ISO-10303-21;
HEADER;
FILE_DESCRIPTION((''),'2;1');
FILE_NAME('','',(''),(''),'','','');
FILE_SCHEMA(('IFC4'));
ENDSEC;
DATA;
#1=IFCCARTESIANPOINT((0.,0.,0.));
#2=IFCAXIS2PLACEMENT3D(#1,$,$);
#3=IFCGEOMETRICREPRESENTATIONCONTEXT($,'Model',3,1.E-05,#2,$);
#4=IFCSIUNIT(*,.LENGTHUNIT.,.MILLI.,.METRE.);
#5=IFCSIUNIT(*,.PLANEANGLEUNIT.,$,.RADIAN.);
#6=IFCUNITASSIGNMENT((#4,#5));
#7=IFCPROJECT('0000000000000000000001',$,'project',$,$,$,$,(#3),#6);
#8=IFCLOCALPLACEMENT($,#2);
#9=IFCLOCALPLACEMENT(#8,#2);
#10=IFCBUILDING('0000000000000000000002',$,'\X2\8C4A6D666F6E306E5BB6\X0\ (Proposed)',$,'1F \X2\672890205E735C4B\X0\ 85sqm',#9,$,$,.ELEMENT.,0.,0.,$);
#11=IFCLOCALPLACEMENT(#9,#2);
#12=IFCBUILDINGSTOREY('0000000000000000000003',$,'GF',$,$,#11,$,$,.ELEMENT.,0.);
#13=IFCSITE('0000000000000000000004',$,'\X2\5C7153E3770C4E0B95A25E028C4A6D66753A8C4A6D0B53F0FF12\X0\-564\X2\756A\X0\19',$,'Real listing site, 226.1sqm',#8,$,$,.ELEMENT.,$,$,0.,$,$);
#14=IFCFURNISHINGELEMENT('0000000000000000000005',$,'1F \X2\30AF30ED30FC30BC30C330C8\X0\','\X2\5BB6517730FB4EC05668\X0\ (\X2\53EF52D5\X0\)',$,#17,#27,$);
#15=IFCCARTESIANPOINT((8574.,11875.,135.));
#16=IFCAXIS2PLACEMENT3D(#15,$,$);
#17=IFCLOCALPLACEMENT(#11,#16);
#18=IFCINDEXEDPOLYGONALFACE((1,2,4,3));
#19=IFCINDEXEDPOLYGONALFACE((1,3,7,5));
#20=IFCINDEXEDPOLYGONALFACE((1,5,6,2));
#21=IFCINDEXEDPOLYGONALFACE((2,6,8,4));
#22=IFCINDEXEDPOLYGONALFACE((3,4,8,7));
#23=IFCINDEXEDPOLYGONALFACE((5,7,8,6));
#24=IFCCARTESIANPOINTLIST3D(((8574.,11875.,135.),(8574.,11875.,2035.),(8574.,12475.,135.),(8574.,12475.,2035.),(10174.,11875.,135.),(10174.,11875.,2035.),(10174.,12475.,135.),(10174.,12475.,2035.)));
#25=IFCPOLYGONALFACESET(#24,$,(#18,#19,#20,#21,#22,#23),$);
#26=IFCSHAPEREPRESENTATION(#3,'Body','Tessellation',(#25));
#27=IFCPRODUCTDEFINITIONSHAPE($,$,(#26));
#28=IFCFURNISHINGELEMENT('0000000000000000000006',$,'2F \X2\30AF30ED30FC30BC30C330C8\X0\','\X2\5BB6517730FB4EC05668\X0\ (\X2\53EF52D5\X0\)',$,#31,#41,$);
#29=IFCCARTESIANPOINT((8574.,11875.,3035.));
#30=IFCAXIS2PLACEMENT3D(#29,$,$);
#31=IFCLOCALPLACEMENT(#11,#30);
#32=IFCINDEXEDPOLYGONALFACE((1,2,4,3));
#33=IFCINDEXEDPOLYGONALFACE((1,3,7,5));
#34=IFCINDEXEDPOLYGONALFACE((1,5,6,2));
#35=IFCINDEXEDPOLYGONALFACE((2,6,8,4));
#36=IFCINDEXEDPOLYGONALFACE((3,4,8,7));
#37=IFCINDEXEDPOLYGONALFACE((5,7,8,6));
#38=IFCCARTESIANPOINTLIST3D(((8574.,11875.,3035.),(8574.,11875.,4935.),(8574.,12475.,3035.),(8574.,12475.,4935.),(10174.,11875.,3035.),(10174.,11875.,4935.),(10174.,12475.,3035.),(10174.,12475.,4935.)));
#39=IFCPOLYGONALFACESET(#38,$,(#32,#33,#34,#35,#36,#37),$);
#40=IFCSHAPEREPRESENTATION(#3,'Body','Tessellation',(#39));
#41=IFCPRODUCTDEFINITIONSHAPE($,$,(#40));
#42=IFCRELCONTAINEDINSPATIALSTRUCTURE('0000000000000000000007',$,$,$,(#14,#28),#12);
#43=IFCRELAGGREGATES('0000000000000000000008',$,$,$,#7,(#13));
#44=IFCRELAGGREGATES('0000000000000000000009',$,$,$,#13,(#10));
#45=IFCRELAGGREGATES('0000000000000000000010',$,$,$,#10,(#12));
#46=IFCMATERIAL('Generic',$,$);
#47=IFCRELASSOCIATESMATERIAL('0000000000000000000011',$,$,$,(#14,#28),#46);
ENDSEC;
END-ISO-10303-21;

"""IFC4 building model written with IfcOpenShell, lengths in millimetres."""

from ifc_helpers import new_model, si_unit, frame, frame_2d, origin, place, context, project, spatial, rectangle, extrude, material, element, save


model = new_model("IFC4")

# Units and contexts
model_context = context("Model", 3, precision=1e-05, world=origin())
ifc_project = project(units=[si_unit("LENGTHUNIT", "METRE", prefix="MILLI"), si_unit("PLANEANGLEUNIT", "RADIAN")], contexts=[model_context])

# Site, building, storey
site_placement = place(None, origin())
site = spatial("IfcSite", under=ifc_project, at=site_placement, Name="山口県下関市豊浦町豊洋台２-564番19", ObjectType="Real listing site, 226.1sqm", CompositionType="ELEMENT", RefElevation=0.0)
building_placement = place(site_placement, origin())
building = spatial("IfcBuilding", under=site, at=building_placement, Name="豊浦潮の家 (Proposed)", ObjectType="1F 木造平屋 85sqm", CompositionType="ELEMENT", ElevationOfRefHeight=0.0, ElevationOfTerrain=0.0)
storey_placement = place(building_placement, origin())
storey = spatial("IfcBuildingStorey", under=building, at=storey_placement, Name="GF", CompositionType="ELEMENT", Elevation=0.0)

# Shared definitions
ifc_material_1 = material(Name="Generic")

# Furnishing elements
furnishing_1_placement = place(storey_placement, frame((8574.0, 11875.0, 135.0)))
element("IfcFurnishingElement", 1, at=furnishing_1_placement, inside=storey, material=ifc_material_1, Name="1F クローゼット", Description="家具・什器 (可動)", context=model_context, shape_type="SweptSolid", body=[
    extrude(rectangle(XDim=1600.0, YDim=600.0, at=frame_2d((800.0, 300.0))), frame((8574.0, 11875.0, 135.0)), (0.0, 0.0, 1.0), 1900.0),
])
furnishing_2_placement = place(storey_placement, frame((8574.0, 11875.0, 3035.0)))
element("IfcFurnishingElement", 2, at=furnishing_2_placement, inside=storey, material=ifc_material_1, Name="2F クローゼット", Description="家具・什器 (可動)", context=model_context, shape_type="SweptSolid", body=[
    extrude(rectangle(XDim=1600.0, YDim=600.0, at=frame_2d((800.0, 300.0))), frame((8574.0, 11875.0, 3035.0)), (0.0, 0.0, 1.0), 1900.0),
])

save(model, "model.ifc")
